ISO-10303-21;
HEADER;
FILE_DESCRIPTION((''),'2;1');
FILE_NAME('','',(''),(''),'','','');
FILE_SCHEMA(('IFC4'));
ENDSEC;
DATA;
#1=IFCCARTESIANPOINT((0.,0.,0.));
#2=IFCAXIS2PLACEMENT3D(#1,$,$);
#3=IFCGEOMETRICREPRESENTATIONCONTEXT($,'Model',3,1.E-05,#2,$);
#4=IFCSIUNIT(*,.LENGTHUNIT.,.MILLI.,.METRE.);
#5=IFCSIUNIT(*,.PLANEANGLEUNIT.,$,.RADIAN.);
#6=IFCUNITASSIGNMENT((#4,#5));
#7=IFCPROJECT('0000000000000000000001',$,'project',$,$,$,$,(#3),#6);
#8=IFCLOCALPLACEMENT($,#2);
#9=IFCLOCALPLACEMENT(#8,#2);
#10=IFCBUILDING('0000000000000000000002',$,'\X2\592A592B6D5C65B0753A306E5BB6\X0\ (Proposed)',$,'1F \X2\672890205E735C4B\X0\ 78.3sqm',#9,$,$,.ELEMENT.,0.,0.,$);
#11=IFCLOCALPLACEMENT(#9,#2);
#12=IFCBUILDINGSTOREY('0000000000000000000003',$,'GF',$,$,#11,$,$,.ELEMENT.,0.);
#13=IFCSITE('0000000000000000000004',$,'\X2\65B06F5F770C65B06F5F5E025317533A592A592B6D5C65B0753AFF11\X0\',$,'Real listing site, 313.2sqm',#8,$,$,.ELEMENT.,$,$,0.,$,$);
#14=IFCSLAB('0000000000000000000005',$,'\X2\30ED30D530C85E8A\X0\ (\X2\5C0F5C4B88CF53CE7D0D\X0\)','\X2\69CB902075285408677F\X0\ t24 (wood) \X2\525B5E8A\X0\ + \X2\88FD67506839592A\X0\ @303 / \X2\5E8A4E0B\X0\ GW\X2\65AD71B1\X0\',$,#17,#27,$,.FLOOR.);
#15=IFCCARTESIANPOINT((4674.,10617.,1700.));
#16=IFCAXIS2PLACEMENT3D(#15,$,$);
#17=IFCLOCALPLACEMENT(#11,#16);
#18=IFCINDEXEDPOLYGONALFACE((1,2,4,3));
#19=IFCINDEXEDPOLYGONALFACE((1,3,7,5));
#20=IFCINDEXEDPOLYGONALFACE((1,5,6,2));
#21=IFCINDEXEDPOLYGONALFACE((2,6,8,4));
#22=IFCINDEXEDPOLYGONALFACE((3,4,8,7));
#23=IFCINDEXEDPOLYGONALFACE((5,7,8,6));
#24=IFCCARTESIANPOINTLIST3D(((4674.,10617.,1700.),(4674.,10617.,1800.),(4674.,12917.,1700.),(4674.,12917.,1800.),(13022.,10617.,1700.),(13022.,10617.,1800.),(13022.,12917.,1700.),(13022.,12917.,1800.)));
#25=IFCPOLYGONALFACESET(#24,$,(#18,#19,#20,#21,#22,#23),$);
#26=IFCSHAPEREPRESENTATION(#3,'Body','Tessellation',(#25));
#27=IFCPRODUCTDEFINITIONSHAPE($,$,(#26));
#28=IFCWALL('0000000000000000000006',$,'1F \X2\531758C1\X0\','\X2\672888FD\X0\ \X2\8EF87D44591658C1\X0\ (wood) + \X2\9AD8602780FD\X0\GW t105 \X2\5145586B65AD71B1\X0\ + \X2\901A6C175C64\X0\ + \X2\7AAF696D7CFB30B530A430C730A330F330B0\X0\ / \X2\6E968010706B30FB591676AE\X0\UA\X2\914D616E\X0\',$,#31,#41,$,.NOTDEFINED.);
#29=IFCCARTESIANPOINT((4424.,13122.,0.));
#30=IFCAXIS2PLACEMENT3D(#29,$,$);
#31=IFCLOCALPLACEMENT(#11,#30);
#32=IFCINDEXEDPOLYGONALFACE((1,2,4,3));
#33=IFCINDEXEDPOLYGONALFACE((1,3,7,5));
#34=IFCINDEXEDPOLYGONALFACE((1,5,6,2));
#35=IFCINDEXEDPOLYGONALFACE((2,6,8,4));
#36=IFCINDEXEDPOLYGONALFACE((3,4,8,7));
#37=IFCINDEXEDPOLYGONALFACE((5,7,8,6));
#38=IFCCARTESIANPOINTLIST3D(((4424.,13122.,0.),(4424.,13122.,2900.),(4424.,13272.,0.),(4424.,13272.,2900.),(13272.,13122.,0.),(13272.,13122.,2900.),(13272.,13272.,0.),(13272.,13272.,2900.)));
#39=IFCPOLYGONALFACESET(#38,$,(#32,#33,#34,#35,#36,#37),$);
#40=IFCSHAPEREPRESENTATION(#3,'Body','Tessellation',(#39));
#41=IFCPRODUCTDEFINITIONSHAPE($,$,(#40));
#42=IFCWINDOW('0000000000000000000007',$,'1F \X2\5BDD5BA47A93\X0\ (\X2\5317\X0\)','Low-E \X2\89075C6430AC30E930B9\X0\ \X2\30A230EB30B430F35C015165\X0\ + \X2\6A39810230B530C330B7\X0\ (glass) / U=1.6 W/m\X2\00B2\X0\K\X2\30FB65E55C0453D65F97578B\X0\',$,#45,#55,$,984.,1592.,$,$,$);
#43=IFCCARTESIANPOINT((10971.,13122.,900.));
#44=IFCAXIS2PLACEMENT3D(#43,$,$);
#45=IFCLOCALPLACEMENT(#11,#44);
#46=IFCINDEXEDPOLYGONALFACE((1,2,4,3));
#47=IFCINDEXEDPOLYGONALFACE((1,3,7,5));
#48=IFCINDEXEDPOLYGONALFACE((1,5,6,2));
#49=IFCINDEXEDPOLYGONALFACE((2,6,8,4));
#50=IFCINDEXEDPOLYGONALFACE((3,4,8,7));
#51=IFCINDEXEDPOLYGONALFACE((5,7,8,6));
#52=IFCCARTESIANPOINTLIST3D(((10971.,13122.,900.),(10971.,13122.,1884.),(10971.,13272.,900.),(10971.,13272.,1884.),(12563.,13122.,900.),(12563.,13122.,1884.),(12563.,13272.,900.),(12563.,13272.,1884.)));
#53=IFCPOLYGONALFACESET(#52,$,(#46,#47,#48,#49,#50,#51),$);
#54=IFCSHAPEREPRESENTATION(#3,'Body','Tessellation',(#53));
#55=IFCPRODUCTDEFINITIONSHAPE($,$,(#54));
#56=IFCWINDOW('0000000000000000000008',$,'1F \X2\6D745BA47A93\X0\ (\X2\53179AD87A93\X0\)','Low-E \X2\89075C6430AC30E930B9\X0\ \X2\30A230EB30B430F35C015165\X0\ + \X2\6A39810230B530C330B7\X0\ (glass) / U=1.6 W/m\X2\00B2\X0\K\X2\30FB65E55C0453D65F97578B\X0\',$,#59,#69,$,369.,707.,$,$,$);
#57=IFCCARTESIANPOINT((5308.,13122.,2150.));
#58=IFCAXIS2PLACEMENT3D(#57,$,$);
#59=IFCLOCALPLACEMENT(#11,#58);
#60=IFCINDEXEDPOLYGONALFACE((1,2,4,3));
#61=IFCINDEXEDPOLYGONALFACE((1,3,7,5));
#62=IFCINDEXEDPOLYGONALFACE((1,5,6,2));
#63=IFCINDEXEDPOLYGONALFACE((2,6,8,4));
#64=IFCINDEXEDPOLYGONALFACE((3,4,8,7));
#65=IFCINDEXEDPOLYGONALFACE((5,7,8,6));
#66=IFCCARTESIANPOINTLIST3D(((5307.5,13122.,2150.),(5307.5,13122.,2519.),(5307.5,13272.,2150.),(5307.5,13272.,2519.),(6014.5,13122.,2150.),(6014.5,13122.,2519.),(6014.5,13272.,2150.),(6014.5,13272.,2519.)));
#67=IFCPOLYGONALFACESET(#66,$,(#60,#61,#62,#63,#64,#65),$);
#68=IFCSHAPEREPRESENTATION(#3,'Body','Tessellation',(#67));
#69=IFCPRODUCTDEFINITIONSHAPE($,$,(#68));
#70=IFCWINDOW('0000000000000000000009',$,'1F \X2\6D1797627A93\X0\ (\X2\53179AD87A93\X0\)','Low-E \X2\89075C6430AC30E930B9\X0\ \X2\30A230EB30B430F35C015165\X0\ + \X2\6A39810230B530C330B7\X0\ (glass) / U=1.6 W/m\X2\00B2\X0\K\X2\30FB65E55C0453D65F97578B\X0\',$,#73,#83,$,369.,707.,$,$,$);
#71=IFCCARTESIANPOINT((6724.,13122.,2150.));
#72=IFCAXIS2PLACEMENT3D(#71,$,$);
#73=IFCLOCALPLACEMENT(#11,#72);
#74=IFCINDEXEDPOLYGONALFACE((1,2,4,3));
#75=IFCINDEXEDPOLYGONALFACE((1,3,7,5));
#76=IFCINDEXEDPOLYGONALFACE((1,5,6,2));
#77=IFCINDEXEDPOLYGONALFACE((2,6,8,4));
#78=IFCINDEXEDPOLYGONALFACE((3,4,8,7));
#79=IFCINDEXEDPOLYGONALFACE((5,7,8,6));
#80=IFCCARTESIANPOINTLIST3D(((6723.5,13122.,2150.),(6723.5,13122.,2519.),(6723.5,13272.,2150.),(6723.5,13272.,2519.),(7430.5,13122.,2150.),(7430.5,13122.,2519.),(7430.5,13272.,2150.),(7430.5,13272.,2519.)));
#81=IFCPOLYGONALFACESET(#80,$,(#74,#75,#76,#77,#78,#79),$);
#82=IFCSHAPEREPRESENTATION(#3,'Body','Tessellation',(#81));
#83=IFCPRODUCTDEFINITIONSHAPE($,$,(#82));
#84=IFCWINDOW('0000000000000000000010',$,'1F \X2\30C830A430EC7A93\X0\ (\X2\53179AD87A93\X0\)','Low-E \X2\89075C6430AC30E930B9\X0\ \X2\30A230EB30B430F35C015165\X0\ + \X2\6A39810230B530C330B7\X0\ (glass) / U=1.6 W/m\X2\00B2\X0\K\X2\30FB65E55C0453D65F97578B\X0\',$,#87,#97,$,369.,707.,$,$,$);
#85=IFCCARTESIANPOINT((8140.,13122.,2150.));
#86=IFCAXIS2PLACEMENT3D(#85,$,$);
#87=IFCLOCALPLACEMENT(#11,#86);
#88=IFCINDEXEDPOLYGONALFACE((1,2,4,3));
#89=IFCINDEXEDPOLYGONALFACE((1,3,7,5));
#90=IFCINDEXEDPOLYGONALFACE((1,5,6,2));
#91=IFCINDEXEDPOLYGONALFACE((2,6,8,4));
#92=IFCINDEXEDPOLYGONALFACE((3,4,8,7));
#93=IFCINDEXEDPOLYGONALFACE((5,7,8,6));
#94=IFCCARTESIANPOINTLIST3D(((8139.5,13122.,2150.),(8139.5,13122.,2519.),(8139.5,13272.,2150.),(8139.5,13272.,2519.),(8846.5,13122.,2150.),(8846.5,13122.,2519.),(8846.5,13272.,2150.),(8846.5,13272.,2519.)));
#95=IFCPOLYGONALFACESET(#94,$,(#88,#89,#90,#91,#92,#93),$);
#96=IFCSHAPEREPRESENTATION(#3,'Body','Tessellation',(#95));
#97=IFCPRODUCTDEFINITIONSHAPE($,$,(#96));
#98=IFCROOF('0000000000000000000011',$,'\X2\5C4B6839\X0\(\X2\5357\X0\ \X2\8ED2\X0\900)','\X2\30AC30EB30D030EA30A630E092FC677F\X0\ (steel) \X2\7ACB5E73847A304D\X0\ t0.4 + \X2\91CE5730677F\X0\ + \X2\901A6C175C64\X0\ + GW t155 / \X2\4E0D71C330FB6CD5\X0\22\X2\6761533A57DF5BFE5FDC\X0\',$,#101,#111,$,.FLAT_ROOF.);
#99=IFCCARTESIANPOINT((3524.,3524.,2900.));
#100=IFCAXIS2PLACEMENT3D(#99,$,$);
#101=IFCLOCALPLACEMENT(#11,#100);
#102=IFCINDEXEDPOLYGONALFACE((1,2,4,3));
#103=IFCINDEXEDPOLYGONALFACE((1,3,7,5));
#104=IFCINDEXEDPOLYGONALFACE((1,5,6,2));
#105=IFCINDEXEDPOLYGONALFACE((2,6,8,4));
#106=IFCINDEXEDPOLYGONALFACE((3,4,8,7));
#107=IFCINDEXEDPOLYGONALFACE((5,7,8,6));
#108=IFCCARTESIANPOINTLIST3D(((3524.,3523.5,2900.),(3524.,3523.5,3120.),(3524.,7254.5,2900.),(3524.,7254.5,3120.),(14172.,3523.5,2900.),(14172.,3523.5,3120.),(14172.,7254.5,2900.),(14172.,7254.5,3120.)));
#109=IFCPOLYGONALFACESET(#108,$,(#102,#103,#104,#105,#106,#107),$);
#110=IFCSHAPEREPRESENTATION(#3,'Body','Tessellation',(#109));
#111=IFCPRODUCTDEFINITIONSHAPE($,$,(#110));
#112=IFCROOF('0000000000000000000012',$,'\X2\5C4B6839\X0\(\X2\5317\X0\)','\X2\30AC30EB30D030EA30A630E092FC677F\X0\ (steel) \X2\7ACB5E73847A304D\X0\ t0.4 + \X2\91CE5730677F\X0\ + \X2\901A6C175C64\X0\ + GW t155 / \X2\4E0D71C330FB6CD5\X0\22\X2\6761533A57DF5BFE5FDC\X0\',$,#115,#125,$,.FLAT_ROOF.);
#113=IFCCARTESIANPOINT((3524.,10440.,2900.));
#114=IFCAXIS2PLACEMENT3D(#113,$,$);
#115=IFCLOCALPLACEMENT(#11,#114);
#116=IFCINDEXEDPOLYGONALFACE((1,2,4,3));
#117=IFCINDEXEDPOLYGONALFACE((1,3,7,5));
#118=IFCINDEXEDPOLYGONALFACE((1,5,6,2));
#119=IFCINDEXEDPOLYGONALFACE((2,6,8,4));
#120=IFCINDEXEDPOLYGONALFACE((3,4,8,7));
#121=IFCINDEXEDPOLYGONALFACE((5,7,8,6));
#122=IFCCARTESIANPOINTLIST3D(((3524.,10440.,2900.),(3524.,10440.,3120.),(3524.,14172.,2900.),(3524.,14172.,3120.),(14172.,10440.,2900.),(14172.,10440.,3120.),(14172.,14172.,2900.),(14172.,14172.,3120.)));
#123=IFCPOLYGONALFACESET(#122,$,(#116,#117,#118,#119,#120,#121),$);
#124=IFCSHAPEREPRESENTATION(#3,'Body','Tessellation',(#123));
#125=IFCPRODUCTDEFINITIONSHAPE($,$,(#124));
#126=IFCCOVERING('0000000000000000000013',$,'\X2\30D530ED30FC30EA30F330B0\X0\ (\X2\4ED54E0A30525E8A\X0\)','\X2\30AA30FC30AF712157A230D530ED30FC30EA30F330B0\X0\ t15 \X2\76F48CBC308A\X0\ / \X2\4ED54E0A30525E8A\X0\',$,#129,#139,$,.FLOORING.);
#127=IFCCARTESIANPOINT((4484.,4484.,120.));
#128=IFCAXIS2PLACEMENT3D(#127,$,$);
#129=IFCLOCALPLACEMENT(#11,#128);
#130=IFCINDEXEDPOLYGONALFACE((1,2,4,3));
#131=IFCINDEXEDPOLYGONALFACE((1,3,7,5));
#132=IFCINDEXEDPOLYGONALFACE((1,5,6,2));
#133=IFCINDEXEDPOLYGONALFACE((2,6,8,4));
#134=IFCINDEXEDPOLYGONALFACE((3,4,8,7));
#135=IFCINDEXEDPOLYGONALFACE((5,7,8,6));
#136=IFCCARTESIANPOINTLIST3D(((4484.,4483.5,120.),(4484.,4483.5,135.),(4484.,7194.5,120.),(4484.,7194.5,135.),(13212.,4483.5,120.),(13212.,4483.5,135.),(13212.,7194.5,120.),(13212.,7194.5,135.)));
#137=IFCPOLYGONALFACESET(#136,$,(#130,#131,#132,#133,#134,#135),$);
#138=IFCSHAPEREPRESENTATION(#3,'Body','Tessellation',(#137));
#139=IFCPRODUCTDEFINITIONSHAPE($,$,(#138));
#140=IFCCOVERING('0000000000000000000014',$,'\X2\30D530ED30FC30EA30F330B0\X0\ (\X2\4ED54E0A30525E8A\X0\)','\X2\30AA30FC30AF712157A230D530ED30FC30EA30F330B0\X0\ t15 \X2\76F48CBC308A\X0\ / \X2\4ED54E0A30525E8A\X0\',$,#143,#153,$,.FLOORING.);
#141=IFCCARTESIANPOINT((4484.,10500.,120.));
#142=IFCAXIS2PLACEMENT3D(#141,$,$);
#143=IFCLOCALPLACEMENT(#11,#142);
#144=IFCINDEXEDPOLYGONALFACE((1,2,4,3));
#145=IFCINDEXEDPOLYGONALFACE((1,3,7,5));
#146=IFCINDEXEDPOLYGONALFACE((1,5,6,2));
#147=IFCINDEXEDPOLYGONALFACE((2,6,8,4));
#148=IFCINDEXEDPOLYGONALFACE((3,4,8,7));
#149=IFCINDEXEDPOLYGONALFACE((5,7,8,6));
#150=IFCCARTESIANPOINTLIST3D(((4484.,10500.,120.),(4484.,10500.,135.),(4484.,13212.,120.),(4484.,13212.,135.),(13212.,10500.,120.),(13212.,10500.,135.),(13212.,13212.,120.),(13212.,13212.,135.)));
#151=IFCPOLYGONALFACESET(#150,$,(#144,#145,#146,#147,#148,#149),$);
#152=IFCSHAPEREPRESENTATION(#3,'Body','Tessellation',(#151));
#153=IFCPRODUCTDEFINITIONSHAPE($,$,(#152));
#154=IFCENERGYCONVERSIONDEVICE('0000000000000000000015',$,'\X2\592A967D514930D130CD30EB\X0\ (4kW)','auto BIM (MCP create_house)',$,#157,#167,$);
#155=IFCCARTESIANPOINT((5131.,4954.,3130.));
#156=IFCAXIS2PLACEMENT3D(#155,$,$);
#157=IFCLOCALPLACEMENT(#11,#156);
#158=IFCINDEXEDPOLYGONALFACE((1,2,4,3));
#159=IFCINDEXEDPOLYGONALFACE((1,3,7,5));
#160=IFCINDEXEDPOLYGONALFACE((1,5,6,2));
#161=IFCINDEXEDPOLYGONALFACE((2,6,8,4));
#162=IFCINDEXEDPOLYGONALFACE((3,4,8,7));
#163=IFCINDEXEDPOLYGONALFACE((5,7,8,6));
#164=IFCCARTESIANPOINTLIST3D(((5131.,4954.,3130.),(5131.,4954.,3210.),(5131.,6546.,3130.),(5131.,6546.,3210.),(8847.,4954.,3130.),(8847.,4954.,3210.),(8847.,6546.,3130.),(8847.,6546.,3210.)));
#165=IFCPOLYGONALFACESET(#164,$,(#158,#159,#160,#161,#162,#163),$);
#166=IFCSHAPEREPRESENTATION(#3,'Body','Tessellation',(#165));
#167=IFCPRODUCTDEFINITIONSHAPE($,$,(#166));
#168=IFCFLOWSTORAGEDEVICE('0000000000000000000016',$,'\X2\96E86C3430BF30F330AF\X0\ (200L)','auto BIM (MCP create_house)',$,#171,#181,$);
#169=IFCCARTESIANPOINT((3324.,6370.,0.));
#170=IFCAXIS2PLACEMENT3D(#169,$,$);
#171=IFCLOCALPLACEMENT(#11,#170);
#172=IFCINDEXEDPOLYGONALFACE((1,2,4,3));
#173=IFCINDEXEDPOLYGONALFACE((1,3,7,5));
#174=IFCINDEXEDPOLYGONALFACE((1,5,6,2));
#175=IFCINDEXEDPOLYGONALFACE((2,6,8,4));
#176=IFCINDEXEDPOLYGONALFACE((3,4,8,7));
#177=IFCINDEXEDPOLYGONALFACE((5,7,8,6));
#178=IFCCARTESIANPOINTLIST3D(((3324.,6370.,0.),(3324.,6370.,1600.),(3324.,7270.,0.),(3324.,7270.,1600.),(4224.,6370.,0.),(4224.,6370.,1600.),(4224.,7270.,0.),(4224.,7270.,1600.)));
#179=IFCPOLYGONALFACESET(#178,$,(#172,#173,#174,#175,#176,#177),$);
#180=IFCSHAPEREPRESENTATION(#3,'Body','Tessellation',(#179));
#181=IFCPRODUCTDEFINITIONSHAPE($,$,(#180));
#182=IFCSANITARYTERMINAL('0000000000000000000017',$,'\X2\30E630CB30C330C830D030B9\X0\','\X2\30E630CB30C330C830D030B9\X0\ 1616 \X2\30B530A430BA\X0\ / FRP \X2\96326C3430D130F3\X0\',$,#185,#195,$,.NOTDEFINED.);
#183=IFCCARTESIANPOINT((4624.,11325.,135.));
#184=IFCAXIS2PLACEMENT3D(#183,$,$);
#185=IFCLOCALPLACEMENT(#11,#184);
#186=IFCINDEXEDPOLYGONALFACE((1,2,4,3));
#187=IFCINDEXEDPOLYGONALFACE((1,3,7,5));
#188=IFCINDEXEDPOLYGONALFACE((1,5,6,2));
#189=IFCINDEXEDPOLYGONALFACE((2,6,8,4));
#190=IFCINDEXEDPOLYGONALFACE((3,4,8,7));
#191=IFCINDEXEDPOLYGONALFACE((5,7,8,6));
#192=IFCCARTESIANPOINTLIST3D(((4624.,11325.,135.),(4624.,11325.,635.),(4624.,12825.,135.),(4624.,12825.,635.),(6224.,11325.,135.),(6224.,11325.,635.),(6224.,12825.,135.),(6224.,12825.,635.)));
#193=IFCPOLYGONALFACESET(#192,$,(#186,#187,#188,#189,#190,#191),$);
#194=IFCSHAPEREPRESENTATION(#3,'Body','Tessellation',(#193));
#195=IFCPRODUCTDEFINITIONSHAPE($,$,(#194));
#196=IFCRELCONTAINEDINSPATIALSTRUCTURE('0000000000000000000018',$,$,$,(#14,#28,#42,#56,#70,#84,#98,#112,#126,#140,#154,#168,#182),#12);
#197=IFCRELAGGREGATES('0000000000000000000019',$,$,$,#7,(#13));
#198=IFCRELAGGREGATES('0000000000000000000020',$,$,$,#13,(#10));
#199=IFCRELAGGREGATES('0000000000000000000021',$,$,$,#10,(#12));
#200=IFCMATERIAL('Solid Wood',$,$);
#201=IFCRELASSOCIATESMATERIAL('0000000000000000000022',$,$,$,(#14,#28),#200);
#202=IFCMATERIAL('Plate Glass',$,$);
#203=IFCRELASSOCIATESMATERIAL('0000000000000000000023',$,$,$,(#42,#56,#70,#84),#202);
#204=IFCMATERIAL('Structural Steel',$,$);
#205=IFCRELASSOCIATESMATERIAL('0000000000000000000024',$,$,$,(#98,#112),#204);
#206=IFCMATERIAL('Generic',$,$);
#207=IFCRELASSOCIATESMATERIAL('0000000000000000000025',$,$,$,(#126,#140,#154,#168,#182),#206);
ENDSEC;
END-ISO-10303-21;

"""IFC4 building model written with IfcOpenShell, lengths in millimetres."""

from ifc_helpers import new_model, si_unit, frame, frame_2d, origin, place, context, project, spatial, rectangle, extrude, material, element, fill, save


model = new_model("IFC4")

# Units and contexts
model_context = context("Model", 3, precision=1e-05, world=origin())
ifc_project = project(units=[si_unit("LENGTHUNIT", "METRE", prefix="MILLI"), si_unit("PLANEANGLEUNIT", "RADIAN")], contexts=[model_context])

# Site, building, storey
site_placement = place(None, origin())
site = spatial("IfcSite", under=ifc_project, at=site_placement, Name="新潟県新潟市北区太夫浜新町１", ObjectType="Real listing site, 313.2sqm", CompositionType="ELEMENT", RefElevation=0.0)
building_placement = place(site_placement, origin())
building = spatial("IfcBuilding", under=site, at=building_placement, Name="太夫浜新町の家 (Proposed)", ObjectType="1F 木造平屋 78.3sqm", CompositionType="ELEMENT", ElevationOfRefHeight=0.0, ElevationOfTerrain=0.0)
storey_placement = place(building_placement, origin())
storey = spatial("IfcBuildingStorey", under=building, at=storey_placement, Name="GF", CompositionType="ELEMENT", Elevation=0.0)

# Slab
ifc_material_1 = material(Name="Solid Wood")
slab_1_placement = place(storey_placement, frame((4674.0, 10617.0, 1700.0)))
element("IfcSlab", 1, at=slab_1_placement, inside=storey, material=ifc_material_1, Name="ロフト床 (小屋裏収納)", Description="構造用合板 t24 (wood) 剛床 + 製材根太 @303 / 床下 GW断熱", PredefinedType="FLOOR", context=model_context, shape_type="SweptSolid", body=[
    extrude(rectangle(XDim=8348.0, YDim=2300.0, at=frame_2d((4174.0, 1150.0))), frame((4674.0, 10617.0, 1700.0)), (0.0, 0.0, 1.0), 100.0),
])

# Shared definitions
ifc_material_2 = material(Name="Plate Glass")

# Wall, openings, windows
wall_1_placement = place(storey_placement, frame((4424.0, 13122.0, 0.0)))
wall_1 = element("IfcWall", 2, at=wall_1_placement, inside=storey, material=ifc_material_1, Name="1F 北壁", Description="木製 軸組外壁 (wood) + 高性能GW t105 充填断熱 + 通気層 + 窯業系サイディング / 準耐火・外皮UA配慮", PredefinedType="NOTDEFINED", context=model_context, shape_type="SweptSolid", body=[
    extrude(rectangle(XDim=8848.0, YDim=150.0, at=frame_2d((4424.0, 75.0))), frame((4424.0, 13122.0, 0.0)), (0.0, 0.0, 1.0), 2900.0),
])
opening_1_placement = place(storey_placement, frame((10971.0, 13122.0, 900.0)))
opening_1 = element("IfcOpeningElement", 3, at=opening_1_placement, cuts=wall_1, PredefinedType="NOTDEFINED", context=model_context, shape_type="SweptSolid", body=[
    extrude(rectangle(XDim=1592.0, YDim=150.0, at=frame_2d((796.0, 75.0))), frame((10971.0, 13122.0, 900.0)), (0.0, 0.0, 1.0), 984.0),
])
opening_2_placement = place(storey_placement, frame((5308.0, 13122.0, 2150.0)))
opening_2 = element("IfcOpeningElement", 4, at=opening_2_placement, cuts=wall_1, PredefinedType="NOTDEFINED", context=model_context, shape_type="SweptSolid", body=[
    extrude(rectangle(XDim=707.0, YDim=150.0, at=frame_2d((353.0, 75.0))), frame((5308.0, 13122.0, 2150.0)), (0.0, 0.0, 1.0), 369.0),
])
opening_3_placement = place(storey_placement, frame((6724.0, 13122.0, 2150.0)))
opening_3 = element("IfcOpeningElement", 5, at=opening_3_placement, cuts=wall_1, PredefinedType="NOTDEFINED", context=model_context, shape_type="SweptSolid", body=[
    extrude(rectangle(XDim=707.0, YDim=150.0, at=frame_2d((353.0, 75.0))), frame((6724.0, 13122.0, 2150.0)), (0.0, 0.0, 1.0), 369.0),
])
opening_4_placement = place(storey_placement, frame((8140.0, 13122.0, 2150.0)))
opening_4 = element("IfcOpeningElement", 6, at=opening_4_placement, cuts=wall_1, PredefinedType="NOTDEFINED", context=model_context, shape_type="SweptSolid", body=[
    extrude(rectangle(XDim=707.0, YDim=150.0, at=frame_2d((353.0, 75.0))), frame((8140.0, 13122.0, 2150.0)), (0.0, 0.0, 1.0), 369.0),
])
window_1_placement = place(storey_placement, frame((10971.0, 13122.0, 900.0)))
window_1 = element("IfcWindow", 7, at=window_1_placement, inside=storey, material=ifc_material_2, Name="1F 寝室窓 (北)", Description="Low-E 複層ガラス アルゴン封入 + 樹脂サッシ (glass) / U=1.6 W/m²K・日射取得型", OverallHeight=984.0, OverallWidth=1592.0, context=model_context, shape_type="SweptSolid", body=[
    extrude(rectangle(XDim=1592.0, YDim=150.0, at=frame_2d((796.0, 75.0))), frame((10971.0, 13122.0, 900.0)), (0.0, 0.0, 1.0), 984.0),
])
fill(opening_1, window_1)
window_2_placement = place(storey_placement, frame((5308.0, 13122.0, 2150.0)))
window_2 = element("IfcWindow", 8, at=window_2_placement, inside=storey, material=ifc_material_2, Name="1F 浴室窓 (北高窓)", Description="Low-E 複層ガラス アルゴン封入 + 樹脂サッシ (glass) / U=1.6 W/m²K・日射取得型", OverallHeight=369.0, OverallWidth=707.0, context=model_context, shape_type="SweptSolid", body=[
    extrude(rectangle(XDim=707.0, YDim=150.0, at=frame_2d((353.0, 75.0))), frame((5308.0, 13122.0, 2150.0)), (0.0, 0.0, 1.0), 369.0),
])
fill(opening_2, window_2)
window_3_placement = place(storey_placement, frame((6724.0, 13122.0, 2150.0)))
window_3 = element("IfcWindow", 9, at=window_3_placement, inside=storey, material=ifc_material_2, Name="1F 洗面窓 (北高窓)", Description="Low-E 複層ガラス アルゴン封入 + 樹脂サッシ (glass) / U=1.6 W/m²K・日射取得型", OverallHeight=369.0, OverallWidth=707.0, context=model_context, shape_type="SweptSolid", body=[
    extrude(rectangle(XDim=707.0, YDim=150.0, at=frame_2d((353.0, 75.0))), frame((6724.0, 13122.0, 2150.0)), (0.0, 0.0, 1.0), 369.0),
])
fill(opening_3, window_3)
window_4_placement = place(storey_placement, frame((8140.0, 13122.0, 2150.0)))
window_4 = element("IfcWindow", 10, at=window_4_placement, inside=storey, material=ifc_material_2, Name="1F トイレ窓 (北高窓)", Description="Low-E 複層ガラス アルゴン封入 + 樹脂サッシ (glass) / U=1.6 W/m²K・日射取得型", OverallHeight=369.0, OverallWidth=707.0, context=model_context, shape_type="SweptSolid", body=[
    extrude(rectangle(XDim=707.0, YDim=150.0, at=frame_2d((353.0, 75.0))), frame((8140.0, 13122.0, 2150.0)), (0.0, 0.0, 1.0), 369.0),
])
fill(opening_4, window_4)

# Roofs
ifc_material_3 = material(Name="Structural Steel")
roof_1_placement = place(storey_placement, frame((3524.0, 3524.0, 2900.0)))
element("IfcRoof", 11, at=roof_1_placement, inside=storey, material=ifc_material_3, Name="屋根(南 軒900)", Description="ガルバリウム鋼板 (steel) 立平葺き t0.4 + 野地板 + 通気層 + GW t155 / 不燃・法22条区域対応", PredefinedType="FLAT_ROOF", context=model_context, shape_type="SweptSolid", body=[
    extrude(rectangle(XDim=10648.0, YDim=3731.0, at=frame_2d((5324.0, 1865.0))), frame((3524.0, 3524.0, 2900.0)), (0.0, 0.0, 1.0), 220.0),
])
roof_2_placement = place(storey_placement, frame((3524.0, 10440.0, 2900.0)))
element("IfcRoof", 12, at=roof_2_placement, inside=storey, material=ifc_material_3, Name="屋根(北)", Description="ガルバリウム鋼板 (steel) 立平葺き t0.4 + 野地板 + 通気層 + GW t155 / 不燃・法22条区域対応", PredefinedType="FLAT_ROOF", context=model_context, shape_type="SweptSolid", body=[
    extrude(rectangle(XDim=10648.0, YDim=3732.0, at=frame_2d((5324.0, 1866.0))), frame((3524.0, 10440.0, 2900.0)), (0.0, 0.0, 1.0), 220.0),
])

# Coverings
ifc_material_4 = material(Name="Generic")
covering_1_placement = place(storey_placement, frame((4484.0, 4484.0, 120.0)))
element("IfcCovering", 13, at=covering_1_placement, inside=storey, material=ifc_material_4, Name="フローリング (仕上げ床)", Description="オーク無垢フローリング t15 直貼り / 仕上げ床", PredefinedType="FLOORING", context=model_context, shape_type="SweptSolid", body=[
    extrude(rectangle(XDim=8728.0, YDim=2711.0, at=frame_2d((4364.0, 1355.0))), frame((4484.0, 4484.0, 120.0)), (0.0, 0.0, 1.0), 15.0),
])
covering_2_placement = place(storey_placement, frame((4484.0, 10500.0, 120.0)))
element("IfcCovering", 14, at=covering_2_placement, inside=storey, material=ifc_material_4, Name="フローリング (仕上げ床)", Description="オーク無垢フローリング t15 直貼り / 仕上げ床", PredefinedType="FLOORING", context=model_context, shape_type="SweptSolid", body=[
    extrude(rectangle(XDim=8728.0, YDim=2712.0, at=frame_2d((4364.0, 1356.0))), frame((4484.0, 10500.0, 120.0)), (0.0, 0.0, 1.0), 15.0),
])

# Energy conversion device
energy_conversion_device_placement = place(storey_placement, frame((5131.0, 4954.0, 3130.0)))
element("IfcEnergyConversionDevice", 15, at=energy_conversion_device_placement, inside=storey, material=ifc_material_4, Name="太陽光パネル (4kW)", Description="auto BIM (MCP create_house)", context=model_context, shape_type="SweptSolid", body=[
    extrude(rectangle(XDim=3716.0, YDim=1592.0, at=frame_2d((1858.0, 796.0))), frame((5131.0, 4954.0, 3130.0)), (0.0, 0.0, 1.0), 80.0),
])

# Flow storage device
flow_storage_device_placement = place(storey_placement, frame((3324.0, 6370.0, 0.0)))
element("IfcFlowStorageDevice", 16, at=flow_storage_device_placement, inside=storey, material=ifc_material_4, Name="雨水タンク (200L)", Description="auto BIM (MCP create_house)", context=model_context, shape_type="SweptSolid", body=[
    extrude(rectangle(XDim=900.0, YDim=900.0, at=frame_2d((450.0, 450.0))), frame((3324.0, 6370.0, 0.0)), (0.0, 0.0, 1.0), 1600.0),
])

# Sanitary terminal
sanitary_terminal_placement = place(storey_placement, frame((4624.0, 11325.0, 135.0)))
element("IfcSanitaryTerminal", 17, at=sanitary_terminal_placement, inside=storey, material=ifc_material_4, Name="ユニットバス", Description="ユニットバス 1616 サイズ / FRP 防水パン", PredefinedType="NOTDEFINED", context=model_context, shape_type="SweptSolid", body=[
    extrude(rectangle(XDim=1600.0, YDim=1500.0, at=frame_2d((800.0, 750.0))), frame((4624.0, 11325.0, 135.0)), (0.0, 0.0, 1.0), 500.0),
])

save(model, "model.ifc")
